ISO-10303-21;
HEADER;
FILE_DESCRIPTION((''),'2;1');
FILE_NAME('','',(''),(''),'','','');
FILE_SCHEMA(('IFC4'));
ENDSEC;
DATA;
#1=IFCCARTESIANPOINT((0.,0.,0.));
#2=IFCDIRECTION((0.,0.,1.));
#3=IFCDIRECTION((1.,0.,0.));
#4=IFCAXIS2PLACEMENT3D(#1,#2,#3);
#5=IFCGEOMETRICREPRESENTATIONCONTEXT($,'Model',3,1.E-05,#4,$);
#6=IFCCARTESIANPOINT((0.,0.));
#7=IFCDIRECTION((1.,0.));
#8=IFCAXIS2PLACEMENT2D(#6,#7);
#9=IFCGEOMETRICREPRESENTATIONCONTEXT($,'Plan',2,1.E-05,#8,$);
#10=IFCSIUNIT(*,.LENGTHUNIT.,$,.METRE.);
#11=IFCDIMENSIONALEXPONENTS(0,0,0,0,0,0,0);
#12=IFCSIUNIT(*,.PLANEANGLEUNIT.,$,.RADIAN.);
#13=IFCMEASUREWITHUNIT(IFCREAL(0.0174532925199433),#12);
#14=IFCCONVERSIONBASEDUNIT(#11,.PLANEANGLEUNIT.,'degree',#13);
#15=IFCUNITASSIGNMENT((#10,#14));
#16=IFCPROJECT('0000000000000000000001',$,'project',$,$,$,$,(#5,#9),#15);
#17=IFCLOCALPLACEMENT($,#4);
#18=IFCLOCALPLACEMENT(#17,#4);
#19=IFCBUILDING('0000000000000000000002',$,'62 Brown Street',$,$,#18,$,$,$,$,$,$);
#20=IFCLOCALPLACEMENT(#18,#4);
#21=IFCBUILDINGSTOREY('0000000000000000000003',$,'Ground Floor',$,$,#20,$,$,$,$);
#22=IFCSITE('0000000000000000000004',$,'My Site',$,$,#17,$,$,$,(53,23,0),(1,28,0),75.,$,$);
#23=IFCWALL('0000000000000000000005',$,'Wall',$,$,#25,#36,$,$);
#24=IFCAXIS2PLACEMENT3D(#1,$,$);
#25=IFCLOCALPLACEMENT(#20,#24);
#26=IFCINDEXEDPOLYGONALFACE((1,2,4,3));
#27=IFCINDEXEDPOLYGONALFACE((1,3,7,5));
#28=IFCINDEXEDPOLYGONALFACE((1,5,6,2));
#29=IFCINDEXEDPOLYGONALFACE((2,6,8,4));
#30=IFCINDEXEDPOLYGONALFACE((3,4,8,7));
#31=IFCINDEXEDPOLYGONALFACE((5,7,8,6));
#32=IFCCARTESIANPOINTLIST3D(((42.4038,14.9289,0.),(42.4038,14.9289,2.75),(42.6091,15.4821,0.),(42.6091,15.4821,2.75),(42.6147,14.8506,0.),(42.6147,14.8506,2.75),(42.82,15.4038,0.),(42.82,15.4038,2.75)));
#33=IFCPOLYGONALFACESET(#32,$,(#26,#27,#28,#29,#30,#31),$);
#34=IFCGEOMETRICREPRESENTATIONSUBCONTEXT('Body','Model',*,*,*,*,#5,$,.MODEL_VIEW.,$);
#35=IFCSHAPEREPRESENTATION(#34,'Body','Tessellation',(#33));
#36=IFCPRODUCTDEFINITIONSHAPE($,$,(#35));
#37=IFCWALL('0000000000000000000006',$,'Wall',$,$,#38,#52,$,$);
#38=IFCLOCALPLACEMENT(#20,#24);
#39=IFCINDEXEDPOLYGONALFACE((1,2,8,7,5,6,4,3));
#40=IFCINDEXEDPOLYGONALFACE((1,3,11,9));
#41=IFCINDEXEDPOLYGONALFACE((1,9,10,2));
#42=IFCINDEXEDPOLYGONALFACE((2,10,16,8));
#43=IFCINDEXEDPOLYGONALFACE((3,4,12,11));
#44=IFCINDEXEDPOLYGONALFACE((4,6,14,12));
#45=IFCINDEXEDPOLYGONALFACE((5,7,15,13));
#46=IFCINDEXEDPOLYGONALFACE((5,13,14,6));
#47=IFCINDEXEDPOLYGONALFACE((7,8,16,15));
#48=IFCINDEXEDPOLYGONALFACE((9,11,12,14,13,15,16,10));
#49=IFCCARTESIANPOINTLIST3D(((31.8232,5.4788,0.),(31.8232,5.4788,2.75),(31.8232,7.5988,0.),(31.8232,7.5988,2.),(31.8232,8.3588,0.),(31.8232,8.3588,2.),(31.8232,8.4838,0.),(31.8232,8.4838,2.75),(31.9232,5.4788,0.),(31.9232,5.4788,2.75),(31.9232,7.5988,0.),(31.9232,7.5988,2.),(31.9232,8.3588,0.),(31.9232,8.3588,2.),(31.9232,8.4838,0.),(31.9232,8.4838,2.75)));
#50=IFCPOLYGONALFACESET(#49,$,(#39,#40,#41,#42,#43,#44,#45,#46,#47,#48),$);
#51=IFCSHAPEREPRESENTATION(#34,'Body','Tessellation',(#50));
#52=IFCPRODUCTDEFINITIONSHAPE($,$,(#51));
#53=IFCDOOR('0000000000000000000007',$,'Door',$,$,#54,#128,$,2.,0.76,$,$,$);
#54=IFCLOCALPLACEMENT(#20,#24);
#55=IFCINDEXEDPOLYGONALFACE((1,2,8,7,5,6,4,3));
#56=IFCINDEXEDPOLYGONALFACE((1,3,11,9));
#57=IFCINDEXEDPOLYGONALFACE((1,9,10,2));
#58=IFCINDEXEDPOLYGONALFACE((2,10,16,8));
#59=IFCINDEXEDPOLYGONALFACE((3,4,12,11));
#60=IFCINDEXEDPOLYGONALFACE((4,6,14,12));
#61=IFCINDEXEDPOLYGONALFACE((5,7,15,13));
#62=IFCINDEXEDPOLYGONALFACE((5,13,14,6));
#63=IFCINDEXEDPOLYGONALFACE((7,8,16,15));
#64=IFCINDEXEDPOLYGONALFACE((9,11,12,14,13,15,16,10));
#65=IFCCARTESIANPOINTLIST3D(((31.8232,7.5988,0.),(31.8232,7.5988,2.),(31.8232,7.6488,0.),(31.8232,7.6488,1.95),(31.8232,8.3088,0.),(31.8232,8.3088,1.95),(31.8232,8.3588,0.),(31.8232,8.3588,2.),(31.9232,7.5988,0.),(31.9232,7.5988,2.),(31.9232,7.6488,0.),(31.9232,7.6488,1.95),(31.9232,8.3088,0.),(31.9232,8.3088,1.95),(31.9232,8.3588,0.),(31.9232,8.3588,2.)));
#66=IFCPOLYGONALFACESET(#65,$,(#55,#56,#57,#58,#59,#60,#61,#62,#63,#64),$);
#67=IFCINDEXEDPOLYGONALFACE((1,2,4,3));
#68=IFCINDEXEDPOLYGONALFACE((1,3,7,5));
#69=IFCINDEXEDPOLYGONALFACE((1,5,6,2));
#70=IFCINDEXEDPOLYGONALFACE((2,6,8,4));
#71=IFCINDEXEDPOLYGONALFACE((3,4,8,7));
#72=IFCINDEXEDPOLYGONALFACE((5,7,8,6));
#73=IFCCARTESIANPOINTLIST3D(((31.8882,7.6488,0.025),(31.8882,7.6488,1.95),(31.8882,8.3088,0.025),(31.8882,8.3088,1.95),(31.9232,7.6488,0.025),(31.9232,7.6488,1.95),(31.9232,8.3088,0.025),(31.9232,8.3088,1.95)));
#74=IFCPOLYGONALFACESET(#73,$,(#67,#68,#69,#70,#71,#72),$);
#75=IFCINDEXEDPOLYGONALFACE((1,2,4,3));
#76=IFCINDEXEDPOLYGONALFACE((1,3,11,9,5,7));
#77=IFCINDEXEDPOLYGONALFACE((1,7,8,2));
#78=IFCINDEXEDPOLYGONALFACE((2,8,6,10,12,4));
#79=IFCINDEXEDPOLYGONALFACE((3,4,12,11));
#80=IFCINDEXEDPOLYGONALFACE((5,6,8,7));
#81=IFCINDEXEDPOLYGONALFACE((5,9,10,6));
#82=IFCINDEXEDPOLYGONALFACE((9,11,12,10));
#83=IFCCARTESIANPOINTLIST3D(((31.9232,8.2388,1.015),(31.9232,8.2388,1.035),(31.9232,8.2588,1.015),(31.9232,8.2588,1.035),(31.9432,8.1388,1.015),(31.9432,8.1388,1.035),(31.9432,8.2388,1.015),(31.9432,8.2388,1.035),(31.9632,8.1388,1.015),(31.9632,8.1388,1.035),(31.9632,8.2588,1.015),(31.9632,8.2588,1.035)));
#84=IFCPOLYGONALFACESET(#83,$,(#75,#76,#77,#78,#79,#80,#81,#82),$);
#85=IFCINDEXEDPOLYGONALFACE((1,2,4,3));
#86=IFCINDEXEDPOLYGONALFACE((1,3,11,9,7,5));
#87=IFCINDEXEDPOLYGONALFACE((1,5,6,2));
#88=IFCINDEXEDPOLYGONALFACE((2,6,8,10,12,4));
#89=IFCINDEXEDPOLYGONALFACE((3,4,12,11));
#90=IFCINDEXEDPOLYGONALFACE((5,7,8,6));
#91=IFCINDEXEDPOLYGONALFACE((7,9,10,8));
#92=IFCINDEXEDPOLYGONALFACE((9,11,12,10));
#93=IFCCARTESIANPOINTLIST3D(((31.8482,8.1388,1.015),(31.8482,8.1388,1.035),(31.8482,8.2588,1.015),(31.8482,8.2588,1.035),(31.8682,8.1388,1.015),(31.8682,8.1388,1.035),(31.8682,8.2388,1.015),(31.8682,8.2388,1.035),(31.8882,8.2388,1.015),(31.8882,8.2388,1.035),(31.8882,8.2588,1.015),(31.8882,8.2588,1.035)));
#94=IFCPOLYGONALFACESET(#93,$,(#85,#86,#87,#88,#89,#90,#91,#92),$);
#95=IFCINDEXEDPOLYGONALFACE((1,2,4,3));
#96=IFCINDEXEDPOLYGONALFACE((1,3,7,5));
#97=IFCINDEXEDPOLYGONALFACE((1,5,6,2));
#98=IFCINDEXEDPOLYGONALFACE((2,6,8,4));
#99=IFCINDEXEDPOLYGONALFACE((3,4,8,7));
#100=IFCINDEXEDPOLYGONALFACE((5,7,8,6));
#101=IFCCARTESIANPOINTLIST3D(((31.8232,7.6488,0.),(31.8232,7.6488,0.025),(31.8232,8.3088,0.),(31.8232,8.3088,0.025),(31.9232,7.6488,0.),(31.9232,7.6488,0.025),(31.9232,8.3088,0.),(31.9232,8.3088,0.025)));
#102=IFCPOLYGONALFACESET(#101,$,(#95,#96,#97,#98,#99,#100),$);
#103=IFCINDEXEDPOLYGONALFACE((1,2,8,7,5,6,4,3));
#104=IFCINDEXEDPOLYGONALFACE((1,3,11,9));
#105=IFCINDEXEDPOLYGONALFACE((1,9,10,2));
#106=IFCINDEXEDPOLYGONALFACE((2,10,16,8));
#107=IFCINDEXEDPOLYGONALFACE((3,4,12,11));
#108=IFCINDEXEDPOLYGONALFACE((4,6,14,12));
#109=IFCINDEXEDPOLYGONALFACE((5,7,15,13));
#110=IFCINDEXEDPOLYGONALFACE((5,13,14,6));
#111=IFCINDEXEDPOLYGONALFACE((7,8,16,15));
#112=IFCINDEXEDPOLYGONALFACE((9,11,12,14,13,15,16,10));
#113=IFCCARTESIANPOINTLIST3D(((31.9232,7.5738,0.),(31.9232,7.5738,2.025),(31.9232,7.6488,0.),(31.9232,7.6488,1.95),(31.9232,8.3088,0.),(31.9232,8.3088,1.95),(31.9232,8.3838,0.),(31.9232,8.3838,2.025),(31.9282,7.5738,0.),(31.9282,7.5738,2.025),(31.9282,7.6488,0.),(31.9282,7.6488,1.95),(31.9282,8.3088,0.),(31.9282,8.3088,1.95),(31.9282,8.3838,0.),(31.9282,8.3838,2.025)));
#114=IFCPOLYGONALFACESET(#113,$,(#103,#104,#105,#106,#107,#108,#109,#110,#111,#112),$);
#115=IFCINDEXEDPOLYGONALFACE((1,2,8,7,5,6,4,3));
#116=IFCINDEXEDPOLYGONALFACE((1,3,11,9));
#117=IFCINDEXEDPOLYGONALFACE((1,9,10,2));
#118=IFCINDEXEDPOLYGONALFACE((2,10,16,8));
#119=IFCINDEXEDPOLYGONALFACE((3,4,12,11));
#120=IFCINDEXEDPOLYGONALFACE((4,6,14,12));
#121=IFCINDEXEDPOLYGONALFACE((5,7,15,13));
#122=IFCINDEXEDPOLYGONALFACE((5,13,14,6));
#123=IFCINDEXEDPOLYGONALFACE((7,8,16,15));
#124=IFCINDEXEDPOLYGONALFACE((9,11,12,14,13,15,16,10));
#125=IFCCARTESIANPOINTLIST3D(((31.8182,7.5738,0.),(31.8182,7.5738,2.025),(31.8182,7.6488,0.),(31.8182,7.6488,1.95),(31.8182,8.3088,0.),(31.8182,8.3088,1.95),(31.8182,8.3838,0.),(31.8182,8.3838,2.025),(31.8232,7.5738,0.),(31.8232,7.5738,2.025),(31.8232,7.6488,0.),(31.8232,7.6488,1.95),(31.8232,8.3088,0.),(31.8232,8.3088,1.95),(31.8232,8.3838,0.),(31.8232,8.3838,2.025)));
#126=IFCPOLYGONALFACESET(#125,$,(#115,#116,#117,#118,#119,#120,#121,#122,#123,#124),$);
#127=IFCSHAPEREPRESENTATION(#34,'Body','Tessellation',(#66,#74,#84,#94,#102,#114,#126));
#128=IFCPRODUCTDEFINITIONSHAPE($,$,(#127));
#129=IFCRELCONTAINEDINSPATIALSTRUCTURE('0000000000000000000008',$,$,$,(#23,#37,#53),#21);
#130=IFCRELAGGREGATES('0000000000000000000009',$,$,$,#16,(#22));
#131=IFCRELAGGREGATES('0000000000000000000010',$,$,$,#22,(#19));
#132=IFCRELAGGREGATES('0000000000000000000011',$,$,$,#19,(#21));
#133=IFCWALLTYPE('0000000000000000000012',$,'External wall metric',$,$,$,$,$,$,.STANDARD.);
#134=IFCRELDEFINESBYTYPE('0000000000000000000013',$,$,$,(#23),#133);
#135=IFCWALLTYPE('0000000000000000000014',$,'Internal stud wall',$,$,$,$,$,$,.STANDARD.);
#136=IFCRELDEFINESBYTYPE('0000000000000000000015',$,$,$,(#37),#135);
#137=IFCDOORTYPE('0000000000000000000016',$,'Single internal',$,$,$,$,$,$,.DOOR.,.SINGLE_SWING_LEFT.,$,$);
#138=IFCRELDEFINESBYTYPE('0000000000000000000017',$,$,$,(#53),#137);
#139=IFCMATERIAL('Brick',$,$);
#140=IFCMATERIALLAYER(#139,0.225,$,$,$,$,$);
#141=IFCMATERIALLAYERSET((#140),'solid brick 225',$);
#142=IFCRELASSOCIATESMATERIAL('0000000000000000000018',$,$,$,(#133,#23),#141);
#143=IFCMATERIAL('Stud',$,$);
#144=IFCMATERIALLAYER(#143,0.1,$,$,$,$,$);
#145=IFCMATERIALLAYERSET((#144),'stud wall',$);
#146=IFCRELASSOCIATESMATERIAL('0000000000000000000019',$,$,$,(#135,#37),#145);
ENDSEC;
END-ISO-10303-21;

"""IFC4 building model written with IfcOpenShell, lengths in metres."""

from ifc_helpers import new_model, entity, si_unit, converted_unit, frame, origin_with_axes, origin_2d_with_axis, place, context, subcontext, project, spatial, line, indexed_curve, outline, extrude, shape, source, transform, mapped, material, layer, layer_set, layer_usage, type_object, type_shapes, element, fill, save


model = new_model("IFC4")

# Units and contexts
model_context = context("Model", 3, precision=1e-05, world=origin_with_axes())
plan_context = context("Plan", 2, precision=1e-05, world=origin_2d_with_axis())
body_context_1 = subcontext(model_context, "Body", "Model", "MODEL_VIEW")
body_context_2 = subcontext(plan_context, "Body", "Plan", "PLAN_VIEW")
ifc_project = project(units=[si_unit("LENGTHUNIT", "METRE"), converted_unit("PLANEANGLEUNIT", "degree", entity("IfcReal", 0.0174532925199433), si_unit("PLANEANGLEUNIT", "RADIAN"), dimensions=[0, 0, 0, 0, 0, 0, 0])], contexts=[model_context, plan_context])

# Site, building, storey
site_placement = place(None, origin_with_axes())
site = spatial("IfcSite", under=ifc_project, at=site_placement, Name="My Site", RefLatitude=(53, 23, 0), RefLongitude=(1, 28, 0), RefElevation=75.0)
building_placement = place(site_placement, origin_with_axes())
building = spatial("IfcBuilding", under=site, at=building_placement, Name="62 Brown Street")
storey_placement = place(building_placement, origin_with_axes())
storey = spatial("IfcBuildingStorey", under=building, at=storey_placement, Name="Ground Floor")

# Shared definitions
ifc_material_1 = material(Name="Brick")
ifc_layer_1 = layer(ifc_material_1, 0.225)
ifc_layer_set_1 = layer_set([ifc_layer_1], Name="solid brick 225")
wall_type_1 = type_object("IfcWallType", Name="External wall metric", PredefinedType="STANDARD", material=ifc_layer_set_1)

# Wall
ifc_layer_usage_1 = layer_usage(ifc_layer_set_1, "AXIS2", "POSITIVE", 0.0)
wall_1_placement = place(storey_placement, frame((42.6147, 14.8506, 0.0), z_axis=(0.0, 0.0, 1.0), x_axis=(0.347944, 0.937515, 0.0)))
element("IfcWall", 1, at=wall_1_placement, inside=storey, type_object=wall_type_1, material=ifc_layer_usage_1, Name="Wall", context=body_context_1, shape_type="SweptSolid", body=[
    extrude(outline(indexed_curve([(0.0, 0.0), (0.0, 0.225), (0.5901, 0.225), (0.5901, 0.0), (0.0, 0.0)], self_intersect=False)), origin_with_axes(), (0.0, 0.0, 1.0), 2.75),
])

# Wall, opening, door
ifc_material_2 = material(Name="Stud")
ifc_layer_2 = layer(ifc_material_2, 0.1)
ifc_layer_set_2 = layer_set([ifc_layer_2], Name="stud wall")
ifc_layer_usage_2 = layer_usage(ifc_layer_set_2, "AXIS2", "POSITIVE", 0.0)
wall_type_2 = type_object("IfcWallType", Name="Internal stud wall", PredefinedType="STANDARD", material=ifc_layer_set_2)
wall_2_placement = place(storey_placement, frame((31.9232, 5.4788, 0.0), z_axis=(0.0, 0.0, 1.0), x_axis=(0.000001, 1.0, 0.0)))
wall_2 = element("IfcWall", 2, at=wall_2_placement, inside=storey, type_object=wall_type_2, material=ifc_layer_usage_2, Name="Wall", context=body_context_1, shape_type="SweptSolid", body=[
    extrude(outline(indexed_curve([(0.0, 0.0), (0.0, 0.1), (3.005, 0.1), (3.005, 0.0), (0.0, 0.0)], self_intersect=False)), origin_with_axes(), (0.0, 0.0, 1.0), 2.75),
])
shared_shape_1 = source(origin_with_axes(), body_context_1, "Body", "SweptSolid", [
    extrude(outline(indexed_curve([(0.0, 0.0), (0.76, 0.0), (0.76, 2.0), (0.0, 2.0)], segments=[line(1, 2, 3, 4, 1)])), frame((0.0, -0.6, 0.0), z_axis=(0.0, -1.0, 0.0), x_axis=(1.0, 0.0, 0.0)), (0.0, 0.0, -1.0), 1.2),
])
opening_1_placement = place(wall_2_placement, frame((2.12, 0.0, 0.0), z_axis=(0.0, 0.0, 1.0), x_axis=(1.0, 0.0, 0.0)))
opening_1 = element("IfcOpeningElement", 3, at=opening_1_placement, cuts=wall_2, PredefinedType="OPENING", context=body_context_1, shape_type="MappedRepresentation", body=[
    mapped(shared_shape_1, transform((0.0, 0.0, 0.0), x_axis=(1.0, 0.0, 0.0), y_axis=(0.0, 1.0, 0.0), z_axis=(0.0, 0.0, 1.0), scale=1.0)),
])
door_type_1 = type_object("IfcDoorType", Name="Single internal", OperationType="SINGLE_SWING_LEFT", PredefinedType="DOOR")
shared_shape_2 = source(origin_with_axes(), body_context_1, "Body", "SweptSolid", [
    extrude(outline(indexed_curve([(0.0, 0.0), (0.0, 2.0), (0.76, 2.0), (0.76, 0.0), (0.71, 0.0), (0.71, 1.95), (0.05, 1.95), (0.05, 0.0)], segments=[line(1, 2, 3, 4, 5, 6, 7, 8, 1)])), frame((0.0, 0.0, 0.0), z_axis=(0.0, -1.0, 0.0), x_axis=(1.0, 0.0, 0.0)), (0.0, 0.0, -1.0), 0.1),
    extrude(outline(indexed_curve([(0.0, 0.0), (0.66, 0.0), (0.66, 0.035), (0.0, 0.035)], segments=[line(1, 2, 3, 4, 1)])), frame((0.05, 0.0, 0.025), z_axis=(0.0, 0.0, 1.0), x_axis=(1.0, 0.0, 0.0)), (0.0, 0.0, 1.0), 1.925),
    extrude(outline(indexed_curve([(0.0, 0.0), (0.0, -0.04), (-0.12, -0.04), (-0.12, -0.02), (-0.02, -0.02), (-0.02, 0.0)], segments=[line(1, 2, 3, 4, 5, 6, 1)])), frame((0.66, 0.0, 1.015), z_axis=(0.0, 0.0, 1.0), x_axis=(1.0, 0.0, 0.0)), (0.0, 0.0, 1.0), 0.02),
    extrude(outline(indexed_curve([(0.0, 0.0), (0.0, 0.04), (-0.12, 0.04), (-0.12, 0.02), (-0.02, 0.02), (-0.02, 0.0)], segments=[line(1, 2, 3, 4, 5, 6, 1)])), frame((0.66, 0.035, 1.015), z_axis=(0.0, 0.0, 1.0), x_axis=(1.0, 0.0, 0.0)), (0.0, 0.0, 1.0), 0.02),
    extrude(outline(indexed_curve([(0.0, 0.0), (0.66, 0.0), (0.66, 0.1), (0.0, 0.1)], segments=[line(1, 2, 3, 4, 1)])), frame((0.05, 0.0, 0.0), z_axis=(0.0, 0.0, 1.0), x_axis=(1.0, 0.0, 0.0)), (0.0, 0.0, 1.0), 0.025),
    extrude(outline(indexed_curve([(0.0, 0.0), (0.0, 2.025), (0.81, 2.025), (0.81, 0.0), (0.735, 0.0), (0.735, 1.95), (0.075, 1.95), (0.075, 0.0)], segments=[line(1, 2, 3, 4, 5, 6, 7, 8, 1)])), frame((-0.025, -0.005, 0.0), z_axis=(0.0, -1.0, 0.0), x_axis=(1.0, 0.0, 0.0)), (0.0, 0.0, -1.0), 0.005),
    extrude(outline(indexed_curve([(0.0, 0.0), (0.0, 2.025), (0.81, 2.025), (0.81, 0.0), (0.735, 0.0), (0.735, 1.95), (0.075, 1.95), (0.075, 0.0)], segments=[line(1, 2, 3, 4, 5, 6, 7, 8, 1)])), frame((-0.025, 0.1, 0.0), z_axis=(0.0, -1.0, 0.0), x_axis=(1.0, 0.0, 0.0)), (0.0, 0.0, -1.0), 0.005),
])
shared_shape_3 = source(origin_with_axes(), body_context_2, "Body", "Curve2D", [
    entity("IfcIndexedPolyCurve", entity("IfcCartesianPointList2D", [[0.0, 0.0], [0.05, 0.0], [0.05, 0.1], [0.0, 0.1]]), [entity("IfcLineIndex", [1, 2, 3, 4, 1])]),
    entity("IfcIndexedPolyCurve", entity("IfcCartesianPointList2D", [[0.76, 0.0], [0.71, 0.0], [0.71, 0.1], [0.76, 0.1]]), [entity("IfcLineIndex", [1, 2, 3, 4, 1])]),
    entity("IfcTrimmedCurve", entity("IfcEllipse", entity("IfcAxis2Placement2D", entity("IfcCartesianPoint", [0.085, 0.1]), entity("IfcDirection", [1.0, 0.0])), 0.625, 0.66), [entity("IfcCartesianPoint", [0.71, 0.1])], [entity("IfcCartesianPoint", [0.085, 0.76])], True, "CARTESIAN"),
    entity("IfcIndexedPolyCurve", entity("IfcCartesianPointList2D", [[0.05, 0.1], [0.085, 0.1], [0.085, 0.76], [0.05, 0.76]]), [entity("IfcLineIndex", [1, 2, 3, 4, 1])]),
])
type_shapes(door_type_1, [shared_shape_2, shared_shape_3])
door_1_placement = place(opening_1_placement, frame((0.0, 0.0, 0.0), z_axis=(0.0, 0.0, 1.0), x_axis=(1.0, 0.0, 0.0)))
door_1 = element("IfcDoor", 4, at=door_1_placement, inside=storey, type_object=door_type_1, Name="Door", OverallHeight=2.0, OverallWidth=0.76, shapes=[
    shape(body_context_1, "Body", "MappedRepresentation", [mapped(shared_shape_2, transform((0.0, 0.0, 0.0), x_axis=(1.0, 0.0, 0.0), y_axis=(0.0, 1.0, 0.0), z_axis=(0.0, 0.0, 1.0), scale=1.0))]),
    shape(body_context_2, "Body", "MappedRepresentation", [mapped(shared_shape_3, transform((0.0, 0.0, 0.0), x_axis=(1.0, 0.0, 0.0), y_axis=(0.0, 1.0, 0.0), z_axis=(0.0, 0.0, 1.0), scale=1.0))]),
])
fill(opening_1, door_1)

save(model, "model.ifc")
